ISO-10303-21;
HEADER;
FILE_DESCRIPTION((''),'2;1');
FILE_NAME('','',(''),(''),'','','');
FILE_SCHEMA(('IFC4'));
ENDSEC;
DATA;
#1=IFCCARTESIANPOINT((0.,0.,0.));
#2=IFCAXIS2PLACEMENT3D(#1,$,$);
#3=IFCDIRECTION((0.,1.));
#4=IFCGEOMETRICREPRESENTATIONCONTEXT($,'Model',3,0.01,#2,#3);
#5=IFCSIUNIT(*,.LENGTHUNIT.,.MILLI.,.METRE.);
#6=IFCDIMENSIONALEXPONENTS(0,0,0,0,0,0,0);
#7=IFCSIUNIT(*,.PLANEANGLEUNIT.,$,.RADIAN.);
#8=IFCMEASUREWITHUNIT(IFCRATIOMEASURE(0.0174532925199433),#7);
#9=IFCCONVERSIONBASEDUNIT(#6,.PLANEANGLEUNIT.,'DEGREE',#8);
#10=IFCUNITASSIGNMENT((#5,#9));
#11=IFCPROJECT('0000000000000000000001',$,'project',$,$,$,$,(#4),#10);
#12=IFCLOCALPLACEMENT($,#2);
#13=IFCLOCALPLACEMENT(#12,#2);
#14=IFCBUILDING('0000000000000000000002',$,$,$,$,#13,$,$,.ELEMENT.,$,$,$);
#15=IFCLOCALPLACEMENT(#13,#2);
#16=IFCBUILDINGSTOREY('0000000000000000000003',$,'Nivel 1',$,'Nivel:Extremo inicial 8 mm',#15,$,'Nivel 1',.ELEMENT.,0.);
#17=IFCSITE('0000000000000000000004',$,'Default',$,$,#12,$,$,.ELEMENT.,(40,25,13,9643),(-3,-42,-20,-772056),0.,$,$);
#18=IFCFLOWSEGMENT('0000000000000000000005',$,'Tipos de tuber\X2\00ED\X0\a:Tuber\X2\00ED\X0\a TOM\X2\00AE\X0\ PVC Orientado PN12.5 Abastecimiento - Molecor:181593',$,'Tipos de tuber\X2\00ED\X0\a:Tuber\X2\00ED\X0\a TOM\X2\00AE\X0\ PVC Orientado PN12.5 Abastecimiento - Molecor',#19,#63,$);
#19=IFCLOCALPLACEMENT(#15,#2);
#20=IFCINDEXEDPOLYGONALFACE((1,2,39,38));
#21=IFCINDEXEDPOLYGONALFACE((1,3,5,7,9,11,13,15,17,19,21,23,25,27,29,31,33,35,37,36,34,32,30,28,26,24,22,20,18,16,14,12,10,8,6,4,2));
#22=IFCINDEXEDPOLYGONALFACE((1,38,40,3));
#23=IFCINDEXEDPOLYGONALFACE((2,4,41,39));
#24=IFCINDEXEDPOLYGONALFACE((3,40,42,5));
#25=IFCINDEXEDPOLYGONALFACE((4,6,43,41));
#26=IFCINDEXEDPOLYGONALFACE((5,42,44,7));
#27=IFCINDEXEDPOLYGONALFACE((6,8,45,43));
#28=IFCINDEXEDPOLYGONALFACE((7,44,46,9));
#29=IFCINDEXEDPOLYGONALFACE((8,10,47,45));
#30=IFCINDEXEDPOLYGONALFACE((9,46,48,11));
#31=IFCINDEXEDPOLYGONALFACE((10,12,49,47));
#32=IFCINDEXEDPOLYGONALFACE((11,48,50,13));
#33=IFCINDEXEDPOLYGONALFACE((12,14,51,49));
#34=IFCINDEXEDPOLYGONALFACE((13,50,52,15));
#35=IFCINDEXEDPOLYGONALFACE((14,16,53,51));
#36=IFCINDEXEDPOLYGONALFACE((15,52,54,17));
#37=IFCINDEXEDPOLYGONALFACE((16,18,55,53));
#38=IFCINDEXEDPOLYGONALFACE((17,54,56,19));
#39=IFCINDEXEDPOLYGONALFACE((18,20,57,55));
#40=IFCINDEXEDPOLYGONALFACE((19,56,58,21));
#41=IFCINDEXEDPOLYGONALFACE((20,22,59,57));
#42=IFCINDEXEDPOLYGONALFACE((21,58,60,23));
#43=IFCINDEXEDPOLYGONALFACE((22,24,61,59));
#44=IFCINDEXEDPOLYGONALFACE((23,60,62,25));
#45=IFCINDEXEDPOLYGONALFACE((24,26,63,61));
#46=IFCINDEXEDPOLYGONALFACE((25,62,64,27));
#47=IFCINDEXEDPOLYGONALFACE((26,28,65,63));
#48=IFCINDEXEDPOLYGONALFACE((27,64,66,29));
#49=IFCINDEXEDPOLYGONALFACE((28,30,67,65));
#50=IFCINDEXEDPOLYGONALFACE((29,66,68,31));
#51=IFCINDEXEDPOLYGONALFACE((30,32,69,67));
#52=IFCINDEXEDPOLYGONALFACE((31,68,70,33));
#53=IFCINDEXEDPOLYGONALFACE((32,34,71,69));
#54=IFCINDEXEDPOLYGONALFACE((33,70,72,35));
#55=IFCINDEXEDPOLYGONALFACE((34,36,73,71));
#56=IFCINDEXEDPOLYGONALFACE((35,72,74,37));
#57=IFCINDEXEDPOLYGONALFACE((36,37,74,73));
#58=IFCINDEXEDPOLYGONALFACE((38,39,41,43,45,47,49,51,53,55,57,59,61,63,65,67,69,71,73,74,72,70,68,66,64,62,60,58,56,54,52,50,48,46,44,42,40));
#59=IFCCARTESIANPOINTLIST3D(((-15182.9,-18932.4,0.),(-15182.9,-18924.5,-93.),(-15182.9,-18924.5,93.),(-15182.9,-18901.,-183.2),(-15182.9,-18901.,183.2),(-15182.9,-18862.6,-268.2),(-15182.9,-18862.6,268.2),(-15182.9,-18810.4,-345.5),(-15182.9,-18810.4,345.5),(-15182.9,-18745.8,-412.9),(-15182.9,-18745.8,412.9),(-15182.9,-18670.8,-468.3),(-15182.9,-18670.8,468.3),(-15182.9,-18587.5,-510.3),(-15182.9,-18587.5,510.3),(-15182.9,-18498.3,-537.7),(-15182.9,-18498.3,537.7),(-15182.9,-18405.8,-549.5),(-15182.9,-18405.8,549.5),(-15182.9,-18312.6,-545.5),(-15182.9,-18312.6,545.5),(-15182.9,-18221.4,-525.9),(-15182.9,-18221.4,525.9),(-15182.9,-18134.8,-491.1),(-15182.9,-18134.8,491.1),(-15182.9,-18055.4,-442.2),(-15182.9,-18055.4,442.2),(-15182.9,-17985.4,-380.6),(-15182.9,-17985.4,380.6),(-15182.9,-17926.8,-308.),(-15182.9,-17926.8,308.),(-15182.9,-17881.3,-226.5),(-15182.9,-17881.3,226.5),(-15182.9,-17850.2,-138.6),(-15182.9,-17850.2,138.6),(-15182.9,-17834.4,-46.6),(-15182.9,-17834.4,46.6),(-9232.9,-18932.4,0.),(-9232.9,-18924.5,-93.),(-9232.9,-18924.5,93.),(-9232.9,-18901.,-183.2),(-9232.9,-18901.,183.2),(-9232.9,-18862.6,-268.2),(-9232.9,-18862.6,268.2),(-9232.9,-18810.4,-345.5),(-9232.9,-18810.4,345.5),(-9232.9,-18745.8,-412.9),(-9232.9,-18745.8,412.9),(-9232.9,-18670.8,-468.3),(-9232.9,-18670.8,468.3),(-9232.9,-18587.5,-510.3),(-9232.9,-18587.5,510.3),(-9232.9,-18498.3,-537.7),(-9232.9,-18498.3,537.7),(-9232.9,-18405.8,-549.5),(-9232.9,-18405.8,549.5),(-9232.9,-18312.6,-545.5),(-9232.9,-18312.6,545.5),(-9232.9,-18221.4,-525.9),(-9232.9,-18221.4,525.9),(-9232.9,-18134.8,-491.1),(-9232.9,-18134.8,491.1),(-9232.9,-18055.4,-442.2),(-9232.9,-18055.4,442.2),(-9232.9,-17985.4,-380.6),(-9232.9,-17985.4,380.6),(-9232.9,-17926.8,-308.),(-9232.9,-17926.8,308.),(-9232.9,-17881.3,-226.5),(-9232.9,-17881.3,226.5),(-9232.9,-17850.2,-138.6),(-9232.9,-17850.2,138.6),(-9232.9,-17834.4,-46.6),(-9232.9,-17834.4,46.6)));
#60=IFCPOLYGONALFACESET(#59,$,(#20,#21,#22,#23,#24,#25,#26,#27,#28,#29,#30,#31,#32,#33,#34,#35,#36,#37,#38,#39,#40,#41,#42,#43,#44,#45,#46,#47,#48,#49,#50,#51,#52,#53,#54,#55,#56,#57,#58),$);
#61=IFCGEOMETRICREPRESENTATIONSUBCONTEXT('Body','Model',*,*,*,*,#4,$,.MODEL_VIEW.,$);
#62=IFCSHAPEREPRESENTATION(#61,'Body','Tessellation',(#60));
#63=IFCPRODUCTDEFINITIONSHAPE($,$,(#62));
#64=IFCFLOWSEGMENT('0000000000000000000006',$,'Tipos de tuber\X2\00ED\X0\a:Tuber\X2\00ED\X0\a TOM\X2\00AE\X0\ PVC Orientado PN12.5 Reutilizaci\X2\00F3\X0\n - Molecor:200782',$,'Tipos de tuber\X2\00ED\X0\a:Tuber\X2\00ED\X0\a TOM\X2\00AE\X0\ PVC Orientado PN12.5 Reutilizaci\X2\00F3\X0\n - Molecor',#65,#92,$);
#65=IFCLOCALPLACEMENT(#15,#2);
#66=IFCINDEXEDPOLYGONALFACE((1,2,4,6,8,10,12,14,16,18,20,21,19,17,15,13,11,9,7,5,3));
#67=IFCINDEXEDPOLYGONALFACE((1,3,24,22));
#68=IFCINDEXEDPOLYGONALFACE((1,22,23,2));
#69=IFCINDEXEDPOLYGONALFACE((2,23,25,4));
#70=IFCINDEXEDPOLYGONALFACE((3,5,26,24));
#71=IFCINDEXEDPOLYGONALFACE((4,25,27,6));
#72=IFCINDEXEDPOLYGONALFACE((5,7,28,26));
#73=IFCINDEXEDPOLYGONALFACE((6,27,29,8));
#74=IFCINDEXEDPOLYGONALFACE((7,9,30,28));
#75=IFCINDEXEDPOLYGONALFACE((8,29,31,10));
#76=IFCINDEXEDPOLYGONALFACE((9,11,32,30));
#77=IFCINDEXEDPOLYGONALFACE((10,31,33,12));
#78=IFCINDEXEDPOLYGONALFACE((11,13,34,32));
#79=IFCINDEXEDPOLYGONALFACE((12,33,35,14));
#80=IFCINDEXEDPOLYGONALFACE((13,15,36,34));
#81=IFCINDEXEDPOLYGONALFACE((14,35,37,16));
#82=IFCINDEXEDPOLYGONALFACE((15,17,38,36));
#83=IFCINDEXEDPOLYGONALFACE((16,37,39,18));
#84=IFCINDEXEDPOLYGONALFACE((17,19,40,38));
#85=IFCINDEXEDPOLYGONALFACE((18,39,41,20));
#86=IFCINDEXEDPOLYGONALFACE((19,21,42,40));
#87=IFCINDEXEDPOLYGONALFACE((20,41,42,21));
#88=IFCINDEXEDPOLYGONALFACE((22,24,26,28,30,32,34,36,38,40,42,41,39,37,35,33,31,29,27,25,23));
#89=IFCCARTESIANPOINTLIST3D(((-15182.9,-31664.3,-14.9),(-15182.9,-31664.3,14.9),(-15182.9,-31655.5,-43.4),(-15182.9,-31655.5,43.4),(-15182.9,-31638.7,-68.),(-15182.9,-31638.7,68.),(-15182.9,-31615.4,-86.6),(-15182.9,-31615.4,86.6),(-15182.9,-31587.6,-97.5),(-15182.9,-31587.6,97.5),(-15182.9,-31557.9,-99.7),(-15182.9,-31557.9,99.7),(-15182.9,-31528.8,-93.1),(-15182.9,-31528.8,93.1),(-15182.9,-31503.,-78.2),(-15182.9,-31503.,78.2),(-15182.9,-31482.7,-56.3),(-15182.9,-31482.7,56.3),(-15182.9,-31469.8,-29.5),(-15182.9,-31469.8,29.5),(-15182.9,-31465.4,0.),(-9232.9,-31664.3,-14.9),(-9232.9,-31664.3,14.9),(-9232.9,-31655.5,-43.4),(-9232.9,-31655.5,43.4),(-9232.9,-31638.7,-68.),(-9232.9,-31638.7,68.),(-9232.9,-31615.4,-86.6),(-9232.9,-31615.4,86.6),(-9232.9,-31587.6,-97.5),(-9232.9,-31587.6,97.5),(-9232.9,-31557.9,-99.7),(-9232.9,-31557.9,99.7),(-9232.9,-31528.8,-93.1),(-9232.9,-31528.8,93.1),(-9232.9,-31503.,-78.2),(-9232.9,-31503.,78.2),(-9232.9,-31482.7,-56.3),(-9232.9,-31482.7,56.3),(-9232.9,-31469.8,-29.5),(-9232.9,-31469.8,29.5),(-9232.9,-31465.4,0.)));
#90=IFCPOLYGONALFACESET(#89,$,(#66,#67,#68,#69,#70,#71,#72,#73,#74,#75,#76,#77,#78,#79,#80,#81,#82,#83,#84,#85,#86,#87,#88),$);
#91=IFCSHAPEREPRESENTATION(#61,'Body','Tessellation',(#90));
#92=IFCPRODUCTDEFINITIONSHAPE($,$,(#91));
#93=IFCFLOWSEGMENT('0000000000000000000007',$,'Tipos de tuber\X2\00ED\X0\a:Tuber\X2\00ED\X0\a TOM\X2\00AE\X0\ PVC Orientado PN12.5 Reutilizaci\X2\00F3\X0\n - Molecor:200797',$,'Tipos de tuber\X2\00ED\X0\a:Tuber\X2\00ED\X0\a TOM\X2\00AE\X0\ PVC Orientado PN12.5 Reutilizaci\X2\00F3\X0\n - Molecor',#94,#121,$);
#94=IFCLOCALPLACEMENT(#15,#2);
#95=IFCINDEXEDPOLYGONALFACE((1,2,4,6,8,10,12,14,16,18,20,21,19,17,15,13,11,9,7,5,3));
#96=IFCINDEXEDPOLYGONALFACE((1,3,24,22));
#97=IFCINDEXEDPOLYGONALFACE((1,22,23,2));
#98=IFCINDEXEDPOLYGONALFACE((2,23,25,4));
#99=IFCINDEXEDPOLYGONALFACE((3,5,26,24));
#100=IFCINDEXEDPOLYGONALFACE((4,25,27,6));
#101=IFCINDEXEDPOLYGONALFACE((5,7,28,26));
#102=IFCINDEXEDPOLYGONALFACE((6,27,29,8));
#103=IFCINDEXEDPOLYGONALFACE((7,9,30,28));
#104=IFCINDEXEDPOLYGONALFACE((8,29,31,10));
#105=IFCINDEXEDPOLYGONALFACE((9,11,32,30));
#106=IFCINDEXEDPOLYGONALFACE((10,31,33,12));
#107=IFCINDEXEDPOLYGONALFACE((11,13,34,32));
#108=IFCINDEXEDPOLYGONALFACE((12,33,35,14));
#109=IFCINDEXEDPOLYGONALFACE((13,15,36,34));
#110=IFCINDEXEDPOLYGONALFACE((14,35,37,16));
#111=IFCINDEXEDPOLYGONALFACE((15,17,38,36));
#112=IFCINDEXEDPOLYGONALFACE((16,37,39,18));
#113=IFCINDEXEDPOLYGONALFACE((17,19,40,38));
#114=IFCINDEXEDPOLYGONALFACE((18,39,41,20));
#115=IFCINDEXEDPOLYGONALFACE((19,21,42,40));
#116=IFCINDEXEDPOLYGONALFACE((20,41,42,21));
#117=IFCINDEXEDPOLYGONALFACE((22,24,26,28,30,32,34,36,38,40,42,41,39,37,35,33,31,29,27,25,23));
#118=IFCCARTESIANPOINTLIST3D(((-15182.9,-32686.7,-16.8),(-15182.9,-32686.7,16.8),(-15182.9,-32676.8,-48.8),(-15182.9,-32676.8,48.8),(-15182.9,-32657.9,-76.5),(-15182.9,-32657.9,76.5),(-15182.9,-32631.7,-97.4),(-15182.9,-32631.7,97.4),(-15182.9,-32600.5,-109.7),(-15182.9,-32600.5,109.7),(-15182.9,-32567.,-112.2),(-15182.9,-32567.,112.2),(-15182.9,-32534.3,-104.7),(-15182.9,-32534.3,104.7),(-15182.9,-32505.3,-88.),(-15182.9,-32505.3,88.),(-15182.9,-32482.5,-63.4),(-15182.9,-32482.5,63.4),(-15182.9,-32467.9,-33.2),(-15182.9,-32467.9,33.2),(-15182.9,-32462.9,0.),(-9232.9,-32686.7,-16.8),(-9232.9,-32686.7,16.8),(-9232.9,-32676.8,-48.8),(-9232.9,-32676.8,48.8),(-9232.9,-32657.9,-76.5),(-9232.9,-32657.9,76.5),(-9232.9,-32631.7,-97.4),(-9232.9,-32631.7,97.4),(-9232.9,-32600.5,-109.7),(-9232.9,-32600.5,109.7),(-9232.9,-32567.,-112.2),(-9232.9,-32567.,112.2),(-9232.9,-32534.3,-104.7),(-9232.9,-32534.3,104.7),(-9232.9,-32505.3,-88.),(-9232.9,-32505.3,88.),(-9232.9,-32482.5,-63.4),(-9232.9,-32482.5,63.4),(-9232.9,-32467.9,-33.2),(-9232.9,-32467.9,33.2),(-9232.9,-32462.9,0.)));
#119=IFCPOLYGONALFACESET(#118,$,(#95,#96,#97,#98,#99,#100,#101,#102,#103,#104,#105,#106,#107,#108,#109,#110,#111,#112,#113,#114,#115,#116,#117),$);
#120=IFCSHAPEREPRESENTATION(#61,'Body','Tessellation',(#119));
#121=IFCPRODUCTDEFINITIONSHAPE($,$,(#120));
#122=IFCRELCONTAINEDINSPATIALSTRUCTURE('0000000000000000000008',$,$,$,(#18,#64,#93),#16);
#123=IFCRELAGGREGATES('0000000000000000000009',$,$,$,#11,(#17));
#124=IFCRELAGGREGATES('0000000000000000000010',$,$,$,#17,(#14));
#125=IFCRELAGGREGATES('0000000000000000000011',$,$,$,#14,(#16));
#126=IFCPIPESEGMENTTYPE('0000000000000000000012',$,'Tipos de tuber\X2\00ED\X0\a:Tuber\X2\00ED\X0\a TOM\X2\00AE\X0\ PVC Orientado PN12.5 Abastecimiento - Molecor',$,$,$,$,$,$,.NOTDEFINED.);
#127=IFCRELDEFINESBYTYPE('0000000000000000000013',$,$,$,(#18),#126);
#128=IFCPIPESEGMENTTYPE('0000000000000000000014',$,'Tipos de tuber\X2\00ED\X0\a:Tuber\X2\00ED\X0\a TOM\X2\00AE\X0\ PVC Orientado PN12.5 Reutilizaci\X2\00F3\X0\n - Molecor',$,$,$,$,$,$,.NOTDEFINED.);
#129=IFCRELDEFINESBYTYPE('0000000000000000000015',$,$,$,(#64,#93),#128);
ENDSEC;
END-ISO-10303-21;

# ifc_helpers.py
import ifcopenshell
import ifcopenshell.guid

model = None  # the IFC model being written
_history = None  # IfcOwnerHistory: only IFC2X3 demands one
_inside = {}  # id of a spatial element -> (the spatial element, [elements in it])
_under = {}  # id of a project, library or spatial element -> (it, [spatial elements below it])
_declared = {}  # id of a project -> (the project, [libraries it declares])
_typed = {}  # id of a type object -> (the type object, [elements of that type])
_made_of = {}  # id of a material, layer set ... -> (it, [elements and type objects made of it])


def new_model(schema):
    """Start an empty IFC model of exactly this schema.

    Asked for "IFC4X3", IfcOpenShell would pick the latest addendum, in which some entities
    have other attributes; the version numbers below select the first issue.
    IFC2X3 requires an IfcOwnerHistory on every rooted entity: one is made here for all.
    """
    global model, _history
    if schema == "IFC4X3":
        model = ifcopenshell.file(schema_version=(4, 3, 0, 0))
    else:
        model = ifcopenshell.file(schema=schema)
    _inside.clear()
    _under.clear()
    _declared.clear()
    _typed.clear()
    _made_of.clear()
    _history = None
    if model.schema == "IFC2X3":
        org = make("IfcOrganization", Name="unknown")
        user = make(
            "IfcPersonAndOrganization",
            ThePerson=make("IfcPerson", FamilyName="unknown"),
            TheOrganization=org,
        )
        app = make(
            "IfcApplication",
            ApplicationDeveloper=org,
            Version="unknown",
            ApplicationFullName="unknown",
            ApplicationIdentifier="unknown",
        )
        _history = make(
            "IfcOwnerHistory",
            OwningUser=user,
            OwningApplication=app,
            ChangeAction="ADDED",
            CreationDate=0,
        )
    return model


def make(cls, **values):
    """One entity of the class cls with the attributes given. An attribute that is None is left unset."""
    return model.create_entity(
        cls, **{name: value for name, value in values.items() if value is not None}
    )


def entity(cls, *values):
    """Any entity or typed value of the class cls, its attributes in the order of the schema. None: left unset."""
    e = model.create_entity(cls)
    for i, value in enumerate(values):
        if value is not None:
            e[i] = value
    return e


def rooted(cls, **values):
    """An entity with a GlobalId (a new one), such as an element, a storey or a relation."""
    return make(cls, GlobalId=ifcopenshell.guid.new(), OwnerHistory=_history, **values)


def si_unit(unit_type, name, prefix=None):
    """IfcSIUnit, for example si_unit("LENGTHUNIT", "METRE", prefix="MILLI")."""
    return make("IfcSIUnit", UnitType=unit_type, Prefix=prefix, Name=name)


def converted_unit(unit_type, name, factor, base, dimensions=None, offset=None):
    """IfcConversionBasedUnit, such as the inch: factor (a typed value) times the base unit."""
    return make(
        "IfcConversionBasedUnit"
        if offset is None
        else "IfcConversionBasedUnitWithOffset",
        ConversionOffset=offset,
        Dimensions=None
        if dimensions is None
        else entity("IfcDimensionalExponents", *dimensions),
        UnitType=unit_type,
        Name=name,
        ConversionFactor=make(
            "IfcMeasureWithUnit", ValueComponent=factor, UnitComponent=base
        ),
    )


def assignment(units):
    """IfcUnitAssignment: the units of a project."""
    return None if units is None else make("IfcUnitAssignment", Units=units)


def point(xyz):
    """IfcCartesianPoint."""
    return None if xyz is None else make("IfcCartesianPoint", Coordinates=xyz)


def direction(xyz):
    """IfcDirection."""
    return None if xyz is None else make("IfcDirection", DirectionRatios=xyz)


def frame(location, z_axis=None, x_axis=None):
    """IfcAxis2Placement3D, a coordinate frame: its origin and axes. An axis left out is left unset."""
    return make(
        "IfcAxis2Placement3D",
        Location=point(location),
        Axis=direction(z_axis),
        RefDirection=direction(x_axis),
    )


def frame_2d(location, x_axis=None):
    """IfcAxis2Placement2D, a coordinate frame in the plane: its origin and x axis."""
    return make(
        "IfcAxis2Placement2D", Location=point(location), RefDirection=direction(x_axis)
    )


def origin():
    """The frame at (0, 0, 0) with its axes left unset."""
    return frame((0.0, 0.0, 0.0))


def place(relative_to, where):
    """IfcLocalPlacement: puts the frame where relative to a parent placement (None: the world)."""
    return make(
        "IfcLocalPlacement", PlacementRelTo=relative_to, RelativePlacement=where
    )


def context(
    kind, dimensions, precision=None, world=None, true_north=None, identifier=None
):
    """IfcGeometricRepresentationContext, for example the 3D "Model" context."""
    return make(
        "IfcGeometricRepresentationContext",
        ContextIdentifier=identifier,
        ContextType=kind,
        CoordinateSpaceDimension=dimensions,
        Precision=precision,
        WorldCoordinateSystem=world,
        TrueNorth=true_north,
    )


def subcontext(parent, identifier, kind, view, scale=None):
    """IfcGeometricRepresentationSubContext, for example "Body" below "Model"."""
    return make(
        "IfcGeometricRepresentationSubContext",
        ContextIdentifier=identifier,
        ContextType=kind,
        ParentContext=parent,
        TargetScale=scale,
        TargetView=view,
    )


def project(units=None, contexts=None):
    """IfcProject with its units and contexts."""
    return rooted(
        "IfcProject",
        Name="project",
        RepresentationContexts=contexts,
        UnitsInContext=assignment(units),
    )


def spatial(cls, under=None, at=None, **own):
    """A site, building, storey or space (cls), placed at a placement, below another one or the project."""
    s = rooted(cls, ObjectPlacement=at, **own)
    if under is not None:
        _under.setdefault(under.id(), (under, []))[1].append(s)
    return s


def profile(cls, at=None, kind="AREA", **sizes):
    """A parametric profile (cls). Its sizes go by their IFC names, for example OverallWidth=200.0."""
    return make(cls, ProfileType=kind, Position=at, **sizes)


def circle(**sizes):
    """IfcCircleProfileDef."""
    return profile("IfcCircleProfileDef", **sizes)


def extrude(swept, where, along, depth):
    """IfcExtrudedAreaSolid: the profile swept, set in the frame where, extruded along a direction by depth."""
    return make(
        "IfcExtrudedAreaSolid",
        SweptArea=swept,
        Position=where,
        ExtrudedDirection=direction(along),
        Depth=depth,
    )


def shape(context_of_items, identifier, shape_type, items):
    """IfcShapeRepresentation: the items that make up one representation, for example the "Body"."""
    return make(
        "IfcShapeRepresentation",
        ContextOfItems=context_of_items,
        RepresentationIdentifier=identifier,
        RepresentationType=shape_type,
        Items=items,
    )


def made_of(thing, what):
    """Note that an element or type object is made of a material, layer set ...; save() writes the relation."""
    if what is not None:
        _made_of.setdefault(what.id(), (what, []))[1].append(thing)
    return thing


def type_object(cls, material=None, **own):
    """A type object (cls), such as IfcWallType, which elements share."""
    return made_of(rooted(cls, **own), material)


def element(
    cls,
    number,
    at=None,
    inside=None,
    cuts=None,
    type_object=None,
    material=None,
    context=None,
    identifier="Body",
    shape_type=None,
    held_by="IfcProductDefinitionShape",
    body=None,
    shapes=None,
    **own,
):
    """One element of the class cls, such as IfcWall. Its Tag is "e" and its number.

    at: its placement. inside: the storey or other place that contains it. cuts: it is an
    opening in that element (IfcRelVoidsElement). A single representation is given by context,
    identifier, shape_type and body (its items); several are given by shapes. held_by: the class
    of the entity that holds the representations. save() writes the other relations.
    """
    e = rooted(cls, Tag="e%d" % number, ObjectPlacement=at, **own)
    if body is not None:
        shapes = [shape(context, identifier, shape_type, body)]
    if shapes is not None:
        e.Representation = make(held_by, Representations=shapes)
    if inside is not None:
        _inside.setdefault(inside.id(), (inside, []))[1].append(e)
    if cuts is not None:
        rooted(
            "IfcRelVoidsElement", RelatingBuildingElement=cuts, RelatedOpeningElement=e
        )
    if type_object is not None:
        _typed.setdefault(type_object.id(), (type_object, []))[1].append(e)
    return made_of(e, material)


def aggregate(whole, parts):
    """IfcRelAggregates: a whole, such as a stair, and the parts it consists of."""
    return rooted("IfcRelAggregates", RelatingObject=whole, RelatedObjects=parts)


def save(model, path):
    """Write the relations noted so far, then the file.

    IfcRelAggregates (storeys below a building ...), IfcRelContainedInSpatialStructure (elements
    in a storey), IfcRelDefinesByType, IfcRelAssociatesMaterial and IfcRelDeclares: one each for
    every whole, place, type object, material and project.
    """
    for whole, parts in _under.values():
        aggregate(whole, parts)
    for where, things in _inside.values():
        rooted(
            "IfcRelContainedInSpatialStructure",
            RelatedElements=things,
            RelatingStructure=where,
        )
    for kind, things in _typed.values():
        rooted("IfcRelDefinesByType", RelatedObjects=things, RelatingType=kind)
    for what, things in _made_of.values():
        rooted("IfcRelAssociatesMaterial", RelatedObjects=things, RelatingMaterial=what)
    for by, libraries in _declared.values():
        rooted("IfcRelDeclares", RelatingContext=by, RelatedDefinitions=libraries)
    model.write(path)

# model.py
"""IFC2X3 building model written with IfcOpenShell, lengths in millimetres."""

from ifc_helpers import new_model, entity, si_unit, converted_unit, direction, frame, frame_2d, origin, place, context, subcontext, project, spatial, circle, extrude, type_object, element, save


model = new_model("IFC2X3")

# Units and contexts
model_context = context("Model", 3, precision=0.01, world=origin(), true_north=direction((0.0, 1.0)))
body_context = subcontext(model_context, "Body", "Model", "MODEL_VIEW")
ifc_project = project(units=[si_unit("LENGTHUNIT", "METRE", prefix="MILLI"), converted_unit("PLANEANGLEUNIT", "DEGREE", entity("IfcRatioMeasure", 0.0174532925199433), si_unit("PLANEANGLEUNIT", "RADIAN"), dimensions=[0, 0, 0, 0, 0, 0, 0])], contexts=[model_context])

# Site, building, storey
site_placement = place(None, origin())
site = spatial("IfcSite", under=ifc_project, at=site_placement, Name="Default", CompositionType="ELEMENT", RefLatitude=(40, 25, 13, 9643), RefLongitude=(-3, -42, -20, -772056), RefElevation=0.0)
building_placement = place(site_placement, origin())
building = spatial("IfcBuilding", under=site, at=building_placement, CompositionType="ELEMENT")
storey_placement = place(building_placement, origin())
storey = spatial("IfcBuildingStorey", under=building, at=storey_placement, Name="Nivel 1", ObjectType="Nivel:Extremo inicial 8 mm", LongName="Nivel 1", CompositionType="ELEMENT", Elevation=0.0)

# Flow segments
pipe_segment_type_1 = type_object("IfcPipeSegmentType", Name="Tipos de tubería:Tubería TOM® PVC Orientado PN12.5 Abastecimiento - Molecor", PredefinedType="NOTDEFINED")
flow_segment_1_placement = place(storey_placement, frame((-15182.9, -18934.0, -551.6)))
element("IfcFlowSegment", 1, at=flow_segment_1_placement, inside=storey, type_object=pipe_segment_type_1, Name="Tipos de tubería:Tubería TOM® PVC Orientado PN12.5 Abastecimiento - Molecor:181593", ObjectType="Tipos de tubería:Tubería TOM® PVC Orientado PN12.5 Abastecimiento - Molecor", context=body_context, shape_type="SweptSolid", body=[
    extrude(circle(Radius=550.0, at=frame_2d((0.0, 0.0), x_axis=(1.0, 0.0))), frame((0.0, 551.6, 551.6), z_axis=(1.0, 0.0, 0.0), x_axis=(0.0, -1.0, 0.0)), (0.0, 0.0, 1.0), 5950.0),
])
pipe_segment_type_2 = type_object("IfcPipeSegmentType", Name="Tipos de tubería:Tubería TOM® PVC Orientado PN12.5 Reutilización - Molecor", PredefinedType="NOTDEFINED")
flow_segment_2_placement = place(storey_placement, frame((-15182.9, -31667.0, -101.6)))
element("IfcFlowSegment", 2, at=flow_segment_2_placement, inside=storey, type_object=pipe_segment_type_2, Name="Tipos de tubería:Tubería TOM® PVC Orientado PN12.5 Reutilización - Molecor:200782", ObjectType="Tipos de tubería:Tubería TOM® PVC Orientado PN12.5 Reutilización - Molecor", context=body_context, shape_type="SweptSolid", body=[
    extrude(circle(Radius=100.0, at=frame_2d((0.0, 0.0), x_axis=(1.0, 0.0))), frame((0.0, 101.6, 101.6), z_axis=(1.0, 0.0, 0.0), x_axis=(0.0, 1.0, 0.0)), (0.0, 0.0, 1.0), 5950.0),
])
flow_segment_3_placement = place(storey_placement, frame((-15182.9, -32689.5, -114.1)))
element("IfcFlowSegment", 3, at=flow_segment_3_placement, inside=storey, type_object=pipe_segment_type_2, Name="Tipos de tubería:Tubería TOM® PVC Orientado PN12.5 Reutilización - Molecor:200797", ObjectType="Tipos de tubería:Tubería TOM® PVC Orientado PN12.5 Reutilización - Molecor", context=body_context, shape_type="SweptSolid", body=[
    extrude(circle(Radius=112.5, at=frame_2d((0.0, 0.0), x_axis=(1.0, 0.0))), frame((0.0, 114.1, 114.1), z_axis=(1.0, 0.0, 0.0), x_axis=(0.0, 1.0, 0.0)), (0.0, 0.0, 1.0), 5950.0),
])

save(model, "model.ifc")
